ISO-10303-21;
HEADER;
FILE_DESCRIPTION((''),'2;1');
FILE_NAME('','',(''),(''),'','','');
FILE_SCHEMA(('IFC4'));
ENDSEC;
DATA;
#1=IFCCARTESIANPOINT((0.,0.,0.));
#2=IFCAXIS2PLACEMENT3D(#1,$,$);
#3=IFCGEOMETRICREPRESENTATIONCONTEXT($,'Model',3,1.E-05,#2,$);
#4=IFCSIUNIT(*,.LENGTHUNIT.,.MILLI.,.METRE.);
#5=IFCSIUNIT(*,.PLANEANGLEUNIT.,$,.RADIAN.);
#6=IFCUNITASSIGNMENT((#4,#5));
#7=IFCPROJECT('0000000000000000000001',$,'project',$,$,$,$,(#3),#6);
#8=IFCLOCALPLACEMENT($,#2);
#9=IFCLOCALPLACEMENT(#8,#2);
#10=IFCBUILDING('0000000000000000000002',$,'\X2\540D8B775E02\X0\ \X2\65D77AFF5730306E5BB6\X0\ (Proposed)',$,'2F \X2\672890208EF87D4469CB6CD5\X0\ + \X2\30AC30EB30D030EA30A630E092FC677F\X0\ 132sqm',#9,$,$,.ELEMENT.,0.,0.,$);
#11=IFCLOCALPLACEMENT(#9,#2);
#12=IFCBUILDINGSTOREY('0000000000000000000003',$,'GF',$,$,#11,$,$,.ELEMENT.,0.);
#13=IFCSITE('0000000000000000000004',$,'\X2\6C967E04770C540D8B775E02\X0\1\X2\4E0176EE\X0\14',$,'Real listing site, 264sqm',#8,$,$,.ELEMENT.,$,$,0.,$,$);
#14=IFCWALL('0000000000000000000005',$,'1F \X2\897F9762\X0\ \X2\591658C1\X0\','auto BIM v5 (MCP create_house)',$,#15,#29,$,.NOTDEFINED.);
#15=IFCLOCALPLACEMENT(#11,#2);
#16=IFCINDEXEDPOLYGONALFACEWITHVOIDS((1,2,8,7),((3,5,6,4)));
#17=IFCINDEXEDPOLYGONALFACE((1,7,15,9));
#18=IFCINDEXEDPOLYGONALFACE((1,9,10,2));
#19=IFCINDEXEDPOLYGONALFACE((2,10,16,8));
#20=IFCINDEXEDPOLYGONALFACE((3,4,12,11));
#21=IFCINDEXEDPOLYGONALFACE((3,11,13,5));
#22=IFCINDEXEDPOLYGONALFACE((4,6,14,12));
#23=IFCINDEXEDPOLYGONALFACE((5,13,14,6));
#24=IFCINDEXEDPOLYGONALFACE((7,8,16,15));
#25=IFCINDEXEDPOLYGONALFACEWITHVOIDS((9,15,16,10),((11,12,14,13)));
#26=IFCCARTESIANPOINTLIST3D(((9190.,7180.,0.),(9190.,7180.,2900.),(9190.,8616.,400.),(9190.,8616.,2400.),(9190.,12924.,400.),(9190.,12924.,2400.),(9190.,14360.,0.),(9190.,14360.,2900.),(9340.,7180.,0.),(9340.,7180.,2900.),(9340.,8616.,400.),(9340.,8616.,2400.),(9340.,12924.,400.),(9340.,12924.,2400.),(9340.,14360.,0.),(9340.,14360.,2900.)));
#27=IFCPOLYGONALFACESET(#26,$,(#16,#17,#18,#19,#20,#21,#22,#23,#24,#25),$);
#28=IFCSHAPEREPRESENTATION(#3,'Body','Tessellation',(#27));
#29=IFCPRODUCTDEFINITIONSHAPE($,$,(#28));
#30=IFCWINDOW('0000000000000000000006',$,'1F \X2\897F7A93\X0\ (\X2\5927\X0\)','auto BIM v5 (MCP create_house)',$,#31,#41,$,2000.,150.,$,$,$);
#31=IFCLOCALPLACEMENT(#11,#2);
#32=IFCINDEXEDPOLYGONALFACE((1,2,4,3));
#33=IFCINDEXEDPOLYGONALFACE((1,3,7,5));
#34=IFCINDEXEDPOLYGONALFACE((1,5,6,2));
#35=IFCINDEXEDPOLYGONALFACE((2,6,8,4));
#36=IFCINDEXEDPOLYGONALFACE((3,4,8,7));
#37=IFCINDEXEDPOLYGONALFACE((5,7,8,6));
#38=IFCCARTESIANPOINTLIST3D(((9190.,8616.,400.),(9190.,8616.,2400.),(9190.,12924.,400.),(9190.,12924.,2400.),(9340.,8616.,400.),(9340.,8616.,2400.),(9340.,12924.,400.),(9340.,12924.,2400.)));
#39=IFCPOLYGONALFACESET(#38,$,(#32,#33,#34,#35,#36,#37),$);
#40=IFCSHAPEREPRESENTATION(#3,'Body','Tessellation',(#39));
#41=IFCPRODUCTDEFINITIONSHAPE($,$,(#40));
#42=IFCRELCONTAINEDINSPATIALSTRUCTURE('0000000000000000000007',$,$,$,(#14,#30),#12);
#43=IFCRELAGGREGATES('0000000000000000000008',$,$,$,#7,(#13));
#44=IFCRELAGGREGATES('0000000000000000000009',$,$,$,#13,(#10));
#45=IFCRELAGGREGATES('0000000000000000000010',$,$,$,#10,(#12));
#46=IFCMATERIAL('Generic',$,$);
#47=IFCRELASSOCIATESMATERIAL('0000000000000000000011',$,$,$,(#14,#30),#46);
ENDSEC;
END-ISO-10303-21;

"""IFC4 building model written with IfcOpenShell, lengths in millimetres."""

from ifc_helpers import new_model, si_unit, frame, frame_2d, origin, place, context, project, spatial, rectangle, extrude, material, element, fill, save


model = new_model("IFC4")

# Units and contexts
model_context = context("Model", 3, precision=1e-05, world=origin())
ifc_project = project(units=[si_unit("LENGTHUNIT", "METRE", prefix="MILLI"), si_unit("PLANEANGLEUNIT", "RADIAN")], contexts=[model_context])

# Site, building, storey
site_placement = place(None, origin())
site = spatial("IfcSite", under=ifc_project, at=site_placement, Name="沖縄県名護市1丁目14", ObjectType="Real listing site, 264sqm", CompositionType="ELEMENT", RefElevation=0.0)
building_placement = place(site_placement, origin())
building = spatial("IfcBuilding", under=site, at=building_placement, Name="名護市 旗竿地の家 (Proposed)", ObjectType="2F 木造軸組構法 + ガルバリウム鋼板 132sqm", CompositionType="ELEMENT", ElevationOfRefHeight=0.0, ElevationOfTerrain=0.0)
storey_placement = place(building_placement, origin())
storey = spatial("IfcBuildingStorey", under=building, at=storey_placement, Name="GF", CompositionType="ELEMENT", Elevation=0.0)

# Shared definitions
ifc_material = material(Name="Generic")

# Wall, opening, window
wall_1_placement = place(storey_placement, frame((4595.0, 3590.0, 0.0)))
wall_1 = element("IfcWall", 1, at=wall_1_placement, inside=storey, material=ifc_material, Name="1F 西面 外壁", Description="auto BIM v5 (MCP create_house)", PredefinedType="NOTDEFINED", context=model_context, shape_type="SweptSolid", body=[
    extrude(rectangle(XDim=150.0, YDim=7180.0, at=frame_2d((75.0, 3590.0))), frame((4595.0, 3590.0, 0.0)), (0.0, 0.0, 1.0), 2900.0),
])
opening_1_placement = place(storey_placement, frame((4595.0, 4308.0, 200.0)))
opening_1 = element("IfcOpeningElement", 2, at=opening_1_placement, cuts=wall_1, PredefinedType="NOTDEFINED", context=model_context, shape_type="SweptSolid", body=[
    extrude(rectangle(XDim=150.0, YDim=4308.0, at=frame_2d((75.0, 2154.0))), frame((4595.0, 4308.0, 200.0)), (0.0, 0.0, 1.0), 2000.0),
])
window_1_placement = place(storey_placement, frame((4595.0, 4308.0, 200.0)))
window_1 = element("IfcWindow", 3, at=window_1_placement, inside=storey, material=ifc_material, Name="1F 西窓 (大)", Description="auto BIM v5 (MCP create_house)", OverallHeight=2000.0, OverallWidth=150.0, context=model_context, shape_type="SweptSolid", body=[
    extrude(rectangle(XDim=150.0, YDim=4308.0, at=frame_2d((75.0, 2154.0))), frame((4595.0, 4308.0, 200.0)), (0.0, 0.0, 1.0), 2000.0),
])
fill(opening_1, window_1)

save(model, "model.ifc")
